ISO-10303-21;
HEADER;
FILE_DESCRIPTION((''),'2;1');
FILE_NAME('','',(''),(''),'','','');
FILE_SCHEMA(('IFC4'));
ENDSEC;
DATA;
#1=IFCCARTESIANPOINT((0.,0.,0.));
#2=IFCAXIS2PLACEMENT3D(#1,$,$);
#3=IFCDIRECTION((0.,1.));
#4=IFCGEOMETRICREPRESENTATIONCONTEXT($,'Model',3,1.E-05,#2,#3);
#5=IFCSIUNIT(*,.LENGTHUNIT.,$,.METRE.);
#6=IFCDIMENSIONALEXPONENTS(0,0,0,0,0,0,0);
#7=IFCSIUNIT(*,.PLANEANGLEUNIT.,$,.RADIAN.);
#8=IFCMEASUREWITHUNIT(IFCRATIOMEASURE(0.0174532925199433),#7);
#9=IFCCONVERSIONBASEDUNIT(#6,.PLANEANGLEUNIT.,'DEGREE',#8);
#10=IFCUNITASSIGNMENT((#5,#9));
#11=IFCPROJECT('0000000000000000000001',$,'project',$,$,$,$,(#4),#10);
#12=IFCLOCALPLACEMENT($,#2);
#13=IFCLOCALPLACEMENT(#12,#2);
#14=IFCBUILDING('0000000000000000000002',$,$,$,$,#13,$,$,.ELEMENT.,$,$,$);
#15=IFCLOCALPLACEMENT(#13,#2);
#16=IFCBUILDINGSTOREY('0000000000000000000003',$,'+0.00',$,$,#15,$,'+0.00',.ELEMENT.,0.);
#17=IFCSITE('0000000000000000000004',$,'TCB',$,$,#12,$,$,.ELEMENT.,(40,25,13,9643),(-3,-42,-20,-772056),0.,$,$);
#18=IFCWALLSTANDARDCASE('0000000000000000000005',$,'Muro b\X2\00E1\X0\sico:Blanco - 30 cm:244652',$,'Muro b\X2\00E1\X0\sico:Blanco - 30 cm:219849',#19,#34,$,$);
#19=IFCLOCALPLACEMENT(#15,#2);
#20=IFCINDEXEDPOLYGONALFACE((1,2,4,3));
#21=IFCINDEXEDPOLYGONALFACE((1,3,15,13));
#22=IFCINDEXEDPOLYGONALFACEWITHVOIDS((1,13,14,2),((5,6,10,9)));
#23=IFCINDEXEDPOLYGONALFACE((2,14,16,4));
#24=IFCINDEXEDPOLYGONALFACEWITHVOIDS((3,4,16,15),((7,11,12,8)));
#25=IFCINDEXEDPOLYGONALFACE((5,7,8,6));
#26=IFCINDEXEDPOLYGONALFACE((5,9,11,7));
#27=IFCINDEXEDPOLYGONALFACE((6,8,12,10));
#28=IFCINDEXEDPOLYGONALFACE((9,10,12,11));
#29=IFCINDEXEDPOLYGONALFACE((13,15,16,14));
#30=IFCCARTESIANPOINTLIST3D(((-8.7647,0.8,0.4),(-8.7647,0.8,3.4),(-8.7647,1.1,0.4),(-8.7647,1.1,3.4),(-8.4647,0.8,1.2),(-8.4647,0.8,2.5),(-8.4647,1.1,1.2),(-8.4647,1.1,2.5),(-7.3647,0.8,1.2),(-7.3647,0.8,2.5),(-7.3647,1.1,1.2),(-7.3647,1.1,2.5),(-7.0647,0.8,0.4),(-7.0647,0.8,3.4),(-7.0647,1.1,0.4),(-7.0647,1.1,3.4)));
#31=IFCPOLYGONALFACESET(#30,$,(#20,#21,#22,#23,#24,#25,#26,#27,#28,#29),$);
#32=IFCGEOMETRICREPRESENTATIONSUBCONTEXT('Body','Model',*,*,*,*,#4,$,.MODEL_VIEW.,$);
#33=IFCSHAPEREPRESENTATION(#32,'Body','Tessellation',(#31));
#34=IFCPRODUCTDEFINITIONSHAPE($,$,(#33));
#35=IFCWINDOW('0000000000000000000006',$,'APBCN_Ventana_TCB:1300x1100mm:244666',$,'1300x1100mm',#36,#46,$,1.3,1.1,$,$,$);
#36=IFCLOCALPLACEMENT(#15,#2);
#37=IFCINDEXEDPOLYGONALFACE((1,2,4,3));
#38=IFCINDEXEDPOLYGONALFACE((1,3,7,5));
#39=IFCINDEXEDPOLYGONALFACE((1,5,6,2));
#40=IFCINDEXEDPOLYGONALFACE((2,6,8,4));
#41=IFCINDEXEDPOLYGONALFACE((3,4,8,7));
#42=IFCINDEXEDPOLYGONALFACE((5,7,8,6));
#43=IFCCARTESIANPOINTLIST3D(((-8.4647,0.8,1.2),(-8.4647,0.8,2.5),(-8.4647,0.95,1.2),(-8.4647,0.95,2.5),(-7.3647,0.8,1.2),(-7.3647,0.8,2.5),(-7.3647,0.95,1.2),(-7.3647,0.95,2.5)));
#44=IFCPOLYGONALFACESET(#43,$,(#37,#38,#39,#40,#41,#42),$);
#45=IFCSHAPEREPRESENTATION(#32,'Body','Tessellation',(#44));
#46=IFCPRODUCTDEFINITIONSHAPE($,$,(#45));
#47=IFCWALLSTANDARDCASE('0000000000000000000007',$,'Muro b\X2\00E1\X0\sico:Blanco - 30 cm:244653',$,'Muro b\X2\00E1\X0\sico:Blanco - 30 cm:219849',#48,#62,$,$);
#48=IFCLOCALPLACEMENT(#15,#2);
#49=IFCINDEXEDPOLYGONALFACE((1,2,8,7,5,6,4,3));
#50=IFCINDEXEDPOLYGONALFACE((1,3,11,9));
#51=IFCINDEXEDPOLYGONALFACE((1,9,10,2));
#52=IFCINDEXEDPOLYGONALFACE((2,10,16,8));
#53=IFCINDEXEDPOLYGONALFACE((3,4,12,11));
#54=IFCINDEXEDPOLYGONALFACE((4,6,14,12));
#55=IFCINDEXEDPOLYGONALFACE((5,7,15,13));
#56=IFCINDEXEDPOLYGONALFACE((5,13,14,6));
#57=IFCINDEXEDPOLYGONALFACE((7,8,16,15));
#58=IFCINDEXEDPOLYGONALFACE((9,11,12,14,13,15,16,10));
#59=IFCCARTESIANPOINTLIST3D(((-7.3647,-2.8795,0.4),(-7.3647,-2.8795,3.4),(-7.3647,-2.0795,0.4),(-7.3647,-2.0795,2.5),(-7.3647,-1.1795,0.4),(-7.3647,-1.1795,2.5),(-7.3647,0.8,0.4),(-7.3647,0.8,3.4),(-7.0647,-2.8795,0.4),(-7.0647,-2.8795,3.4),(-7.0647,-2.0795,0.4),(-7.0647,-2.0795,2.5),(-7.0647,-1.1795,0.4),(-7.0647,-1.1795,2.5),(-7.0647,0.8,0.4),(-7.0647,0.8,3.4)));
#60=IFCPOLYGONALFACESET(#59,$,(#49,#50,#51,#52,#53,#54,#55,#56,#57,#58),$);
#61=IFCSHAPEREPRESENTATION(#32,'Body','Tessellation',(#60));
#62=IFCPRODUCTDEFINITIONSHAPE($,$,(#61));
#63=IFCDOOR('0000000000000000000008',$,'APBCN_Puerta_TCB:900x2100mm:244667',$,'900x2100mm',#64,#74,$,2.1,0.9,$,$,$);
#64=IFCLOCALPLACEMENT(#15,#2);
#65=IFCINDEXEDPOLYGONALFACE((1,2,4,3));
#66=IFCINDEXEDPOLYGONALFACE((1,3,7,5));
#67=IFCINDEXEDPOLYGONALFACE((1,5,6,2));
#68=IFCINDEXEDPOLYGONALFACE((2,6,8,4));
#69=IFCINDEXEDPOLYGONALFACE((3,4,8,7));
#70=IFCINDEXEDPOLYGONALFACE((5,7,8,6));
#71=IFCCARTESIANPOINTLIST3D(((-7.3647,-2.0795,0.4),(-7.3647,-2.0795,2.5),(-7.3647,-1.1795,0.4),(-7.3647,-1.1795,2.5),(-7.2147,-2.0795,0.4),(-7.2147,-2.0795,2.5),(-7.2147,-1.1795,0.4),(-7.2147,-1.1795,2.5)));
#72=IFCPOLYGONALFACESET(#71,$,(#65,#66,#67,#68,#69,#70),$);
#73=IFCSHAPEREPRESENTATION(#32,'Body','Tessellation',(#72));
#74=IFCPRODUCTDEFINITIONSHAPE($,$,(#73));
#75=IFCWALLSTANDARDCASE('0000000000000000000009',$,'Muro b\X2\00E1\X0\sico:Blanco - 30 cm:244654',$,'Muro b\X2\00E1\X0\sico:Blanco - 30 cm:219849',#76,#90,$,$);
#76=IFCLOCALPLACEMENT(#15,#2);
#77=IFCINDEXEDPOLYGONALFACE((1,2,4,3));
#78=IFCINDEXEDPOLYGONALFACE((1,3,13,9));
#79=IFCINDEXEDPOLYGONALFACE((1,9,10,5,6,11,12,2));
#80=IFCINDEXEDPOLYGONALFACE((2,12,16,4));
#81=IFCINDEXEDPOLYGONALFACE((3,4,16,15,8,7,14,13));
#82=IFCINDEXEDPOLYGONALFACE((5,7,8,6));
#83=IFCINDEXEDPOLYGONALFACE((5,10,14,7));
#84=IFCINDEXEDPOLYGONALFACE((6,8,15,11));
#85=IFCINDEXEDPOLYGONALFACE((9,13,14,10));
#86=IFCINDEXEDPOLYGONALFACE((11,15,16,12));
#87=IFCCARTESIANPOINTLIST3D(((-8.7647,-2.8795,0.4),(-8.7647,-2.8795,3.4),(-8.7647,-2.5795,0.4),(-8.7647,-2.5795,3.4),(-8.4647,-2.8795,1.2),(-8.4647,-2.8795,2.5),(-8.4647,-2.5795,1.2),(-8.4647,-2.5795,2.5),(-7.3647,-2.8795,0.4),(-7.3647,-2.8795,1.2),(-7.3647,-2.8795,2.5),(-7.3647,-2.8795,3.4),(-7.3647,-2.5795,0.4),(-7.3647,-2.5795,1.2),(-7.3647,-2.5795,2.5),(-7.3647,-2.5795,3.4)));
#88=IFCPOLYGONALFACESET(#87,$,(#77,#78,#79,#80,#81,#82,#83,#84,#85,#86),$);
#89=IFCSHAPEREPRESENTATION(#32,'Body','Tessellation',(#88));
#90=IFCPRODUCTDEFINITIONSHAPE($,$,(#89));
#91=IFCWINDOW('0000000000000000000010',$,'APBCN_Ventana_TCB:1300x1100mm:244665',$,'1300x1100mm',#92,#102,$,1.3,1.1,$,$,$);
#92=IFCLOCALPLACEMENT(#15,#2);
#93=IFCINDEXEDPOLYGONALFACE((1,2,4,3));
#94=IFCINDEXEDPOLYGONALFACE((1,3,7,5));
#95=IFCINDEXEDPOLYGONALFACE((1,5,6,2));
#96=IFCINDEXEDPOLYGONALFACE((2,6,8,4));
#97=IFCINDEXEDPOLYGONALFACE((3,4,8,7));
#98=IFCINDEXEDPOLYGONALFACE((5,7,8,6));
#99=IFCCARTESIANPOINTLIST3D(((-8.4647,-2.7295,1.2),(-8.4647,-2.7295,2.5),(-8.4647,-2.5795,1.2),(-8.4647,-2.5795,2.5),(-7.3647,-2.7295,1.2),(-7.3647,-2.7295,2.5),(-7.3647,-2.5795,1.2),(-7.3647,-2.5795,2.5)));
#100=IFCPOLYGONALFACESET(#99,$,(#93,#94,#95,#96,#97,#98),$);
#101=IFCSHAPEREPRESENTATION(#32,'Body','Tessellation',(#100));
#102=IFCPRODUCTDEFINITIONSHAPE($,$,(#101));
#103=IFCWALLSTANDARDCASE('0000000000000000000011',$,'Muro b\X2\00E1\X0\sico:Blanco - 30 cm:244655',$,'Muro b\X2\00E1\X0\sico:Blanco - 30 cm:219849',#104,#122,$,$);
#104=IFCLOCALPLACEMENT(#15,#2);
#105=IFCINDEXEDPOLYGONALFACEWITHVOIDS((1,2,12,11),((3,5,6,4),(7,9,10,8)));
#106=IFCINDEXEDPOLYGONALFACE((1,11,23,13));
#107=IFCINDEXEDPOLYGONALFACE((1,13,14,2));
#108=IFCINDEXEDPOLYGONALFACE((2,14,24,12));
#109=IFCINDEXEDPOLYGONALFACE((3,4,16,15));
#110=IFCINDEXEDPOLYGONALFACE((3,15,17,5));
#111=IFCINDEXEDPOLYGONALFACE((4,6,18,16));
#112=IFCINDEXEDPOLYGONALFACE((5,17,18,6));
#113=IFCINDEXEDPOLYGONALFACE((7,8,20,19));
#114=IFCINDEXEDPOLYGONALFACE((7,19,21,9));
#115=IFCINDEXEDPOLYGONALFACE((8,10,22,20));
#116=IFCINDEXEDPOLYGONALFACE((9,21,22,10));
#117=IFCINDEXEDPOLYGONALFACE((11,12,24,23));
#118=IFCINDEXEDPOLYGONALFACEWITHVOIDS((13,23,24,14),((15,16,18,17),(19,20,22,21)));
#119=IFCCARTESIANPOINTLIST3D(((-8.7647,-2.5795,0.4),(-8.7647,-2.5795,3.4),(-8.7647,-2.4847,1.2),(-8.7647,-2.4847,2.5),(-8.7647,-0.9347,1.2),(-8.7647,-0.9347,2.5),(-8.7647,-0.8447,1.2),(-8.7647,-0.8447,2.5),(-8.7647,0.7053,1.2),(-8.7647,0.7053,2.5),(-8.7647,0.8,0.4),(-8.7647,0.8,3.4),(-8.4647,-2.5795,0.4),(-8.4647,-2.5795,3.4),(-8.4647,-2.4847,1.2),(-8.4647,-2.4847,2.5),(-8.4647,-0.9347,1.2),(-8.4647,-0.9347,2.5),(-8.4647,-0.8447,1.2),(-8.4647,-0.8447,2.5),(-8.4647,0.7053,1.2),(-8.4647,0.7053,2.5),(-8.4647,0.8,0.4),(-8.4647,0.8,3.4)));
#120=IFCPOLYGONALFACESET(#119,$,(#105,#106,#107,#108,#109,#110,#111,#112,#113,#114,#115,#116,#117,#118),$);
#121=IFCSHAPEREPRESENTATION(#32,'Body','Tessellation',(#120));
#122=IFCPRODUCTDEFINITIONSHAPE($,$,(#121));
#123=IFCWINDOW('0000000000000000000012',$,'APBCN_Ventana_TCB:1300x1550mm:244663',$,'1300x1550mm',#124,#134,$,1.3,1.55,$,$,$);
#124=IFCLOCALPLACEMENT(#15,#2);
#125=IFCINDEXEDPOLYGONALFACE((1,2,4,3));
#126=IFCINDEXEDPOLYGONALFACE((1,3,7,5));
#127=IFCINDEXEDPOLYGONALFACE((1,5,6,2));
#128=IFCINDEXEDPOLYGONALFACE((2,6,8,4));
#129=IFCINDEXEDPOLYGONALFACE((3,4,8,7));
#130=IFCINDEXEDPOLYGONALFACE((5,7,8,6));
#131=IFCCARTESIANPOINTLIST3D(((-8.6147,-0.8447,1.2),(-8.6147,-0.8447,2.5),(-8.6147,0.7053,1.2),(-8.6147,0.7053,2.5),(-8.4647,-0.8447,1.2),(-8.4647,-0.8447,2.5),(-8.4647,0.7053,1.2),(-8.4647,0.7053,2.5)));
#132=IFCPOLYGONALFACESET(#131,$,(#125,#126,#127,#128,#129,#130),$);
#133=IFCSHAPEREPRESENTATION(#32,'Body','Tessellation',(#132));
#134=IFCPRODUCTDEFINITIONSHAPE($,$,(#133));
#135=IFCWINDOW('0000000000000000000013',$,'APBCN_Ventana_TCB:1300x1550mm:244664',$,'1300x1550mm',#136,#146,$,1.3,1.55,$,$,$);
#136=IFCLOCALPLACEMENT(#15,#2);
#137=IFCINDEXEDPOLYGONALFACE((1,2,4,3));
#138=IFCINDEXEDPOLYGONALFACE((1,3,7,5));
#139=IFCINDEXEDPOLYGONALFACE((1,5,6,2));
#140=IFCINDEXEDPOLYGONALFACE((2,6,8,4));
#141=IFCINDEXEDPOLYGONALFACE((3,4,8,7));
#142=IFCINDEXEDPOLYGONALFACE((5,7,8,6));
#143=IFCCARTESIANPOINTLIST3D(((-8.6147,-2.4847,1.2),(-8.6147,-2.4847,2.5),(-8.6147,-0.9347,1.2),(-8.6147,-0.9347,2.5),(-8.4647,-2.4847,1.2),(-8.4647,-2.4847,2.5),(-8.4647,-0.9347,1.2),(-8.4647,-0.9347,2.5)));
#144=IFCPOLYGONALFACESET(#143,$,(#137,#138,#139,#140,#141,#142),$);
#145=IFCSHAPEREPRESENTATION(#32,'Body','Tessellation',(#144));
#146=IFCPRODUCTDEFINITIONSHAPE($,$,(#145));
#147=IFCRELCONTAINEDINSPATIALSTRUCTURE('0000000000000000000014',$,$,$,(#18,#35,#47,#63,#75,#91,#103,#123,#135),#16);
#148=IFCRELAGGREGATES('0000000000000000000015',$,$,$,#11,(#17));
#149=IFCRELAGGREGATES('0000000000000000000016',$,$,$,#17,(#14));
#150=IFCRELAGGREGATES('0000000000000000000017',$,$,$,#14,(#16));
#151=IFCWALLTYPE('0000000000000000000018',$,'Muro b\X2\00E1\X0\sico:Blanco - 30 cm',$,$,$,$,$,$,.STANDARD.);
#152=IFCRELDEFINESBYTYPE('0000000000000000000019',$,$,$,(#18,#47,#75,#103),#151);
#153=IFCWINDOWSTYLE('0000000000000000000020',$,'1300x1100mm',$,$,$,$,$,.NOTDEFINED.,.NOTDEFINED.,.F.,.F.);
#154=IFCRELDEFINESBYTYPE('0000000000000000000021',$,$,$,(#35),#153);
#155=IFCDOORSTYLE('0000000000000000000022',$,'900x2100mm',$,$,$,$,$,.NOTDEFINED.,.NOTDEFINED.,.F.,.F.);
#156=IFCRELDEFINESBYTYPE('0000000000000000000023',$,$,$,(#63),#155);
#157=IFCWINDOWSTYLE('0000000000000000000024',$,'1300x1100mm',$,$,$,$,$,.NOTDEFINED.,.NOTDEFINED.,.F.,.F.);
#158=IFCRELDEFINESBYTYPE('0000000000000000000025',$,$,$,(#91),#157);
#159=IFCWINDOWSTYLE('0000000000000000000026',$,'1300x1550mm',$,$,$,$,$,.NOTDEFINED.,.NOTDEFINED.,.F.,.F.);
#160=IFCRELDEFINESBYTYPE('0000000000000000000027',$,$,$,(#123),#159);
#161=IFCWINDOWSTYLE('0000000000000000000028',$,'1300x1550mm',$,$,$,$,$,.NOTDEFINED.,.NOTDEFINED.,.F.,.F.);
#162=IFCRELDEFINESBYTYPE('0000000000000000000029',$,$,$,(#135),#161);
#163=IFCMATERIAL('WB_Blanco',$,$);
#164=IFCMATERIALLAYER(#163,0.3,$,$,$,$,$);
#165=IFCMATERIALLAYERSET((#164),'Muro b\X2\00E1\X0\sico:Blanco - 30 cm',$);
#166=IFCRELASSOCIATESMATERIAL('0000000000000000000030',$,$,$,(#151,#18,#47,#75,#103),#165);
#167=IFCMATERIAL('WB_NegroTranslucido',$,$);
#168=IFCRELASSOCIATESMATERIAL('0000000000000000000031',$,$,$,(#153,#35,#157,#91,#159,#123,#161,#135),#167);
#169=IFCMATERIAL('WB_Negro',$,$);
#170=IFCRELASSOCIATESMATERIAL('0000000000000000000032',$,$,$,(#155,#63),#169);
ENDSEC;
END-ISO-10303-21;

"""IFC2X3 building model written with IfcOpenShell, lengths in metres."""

from ifc_helpers import new_model, entity, si_unit, converted_unit, direction, frame, frame_2d, origin, origin_2d_with_axis, place, context, subcontext, project, spatial, rectangle, extrude, source, transform, mapped, material, layer, layer_set, layer_usage, type_object, type_shapes, element, fill, save


model = new_model("IFC2X3")

# Units and contexts
model_context = context("Model", 3, precision=1e-05, world=origin(), true_north=direction((0.0, 1.0)))
body_context = subcontext(model_context, "Body", "Model", "MODEL_VIEW")
ifc_project = project(units=[si_unit("LENGTHUNIT", "METRE"), converted_unit("PLANEANGLEUNIT", "DEGREE", entity("IfcRatioMeasure", 0.0174532925199433), si_unit("PLANEANGLEUNIT", "RADIAN"), dimensions=[0, 0, 0, 0, 0, 0, 0])], contexts=[model_context])

# Site, building, storey
site_placement = place(None, origin())
site = spatial("IfcSite", under=ifc_project, at=site_placement, Name="TCB", CompositionType="ELEMENT", RefLatitude=(40, 25, 13, 9643), RefLongitude=(-3, -42, -20, -772056), RefElevation=0.0)
building_placement = place(site_placement, origin())
building = spatial("IfcBuilding", under=site, at=building_placement, CompositionType="ELEMENT")
storey_placement = place(building_placement, origin())
storey = spatial("IfcBuildingStorey", under=building, at=storey_placement, Name="+0.00", LongName="+0.00", CompositionType="ELEMENT", Elevation=0.0)

# Wall, opening, window
ifc_material_1 = material(Name="WB_Blanco")
ifc_layer_1 = layer(ifc_material_1, 0.3)
ifc_layer_set_1 = layer_set([ifc_layer_1], Name="Muro básico:Blanco - 30 cm")
ifc_layer_usage_1 = layer_usage(ifc_layer_set_1, "AXIS2", "NEGATIVE", 0.15)
wall_type = type_object("IfcWallType", Name="Muro básico:Blanco - 30 cm", PredefinedType="STANDARD", material=ifc_layer_set_1)
wall_1_placement = place(storey_placement, frame((-8.7647, 0.95, 0.4)))
wall_1 = element("IfcWallStandardCase", 1, at=wall_1_placement, inside=storey, type_object=wall_type, material=ifc_layer_usage_1, Name="Muro básico:Blanco - 30 cm:244652", ObjectType="Muro básico:Blanco - 30 cm:219849", context=body_context, shape_type="SweptSolid", body=[
    extrude(rectangle(XDim=1.7, YDim=0.3, at=frame_2d((0.85, 0.0), x_axis=(-1.0, 0.0))), origin(), (0.0, 0.0, 1.0), 3.0),
])
opening_1_placement = place(wall_1_placement, frame((0.3, -0.15, 0.8)))
opening_1 = element("IfcOpeningElement", 2, at=opening_1_placement, cuts=wall_1, ObjectType="Opening", context=body_context, shape_type="SweptSolid", body=[
    extrude(rectangle(XDim=1.3, YDim=1.1, at=frame_2d((0.65, 0.55), x_axis=(1.0, 0.0))), frame((0.0, 0.0, 0.0), z_axis=(0.0, 1.0, 0.0), x_axis=(0.0, 0.0, 1.0)), (0.0, 0.0, 1.0), 0.3),
])
ifc_material_2 = material(Name="WB_NegroTranslucido")
window_style_1 = type_object("IfcWindowStyle", Name="1300x1100mm", ConstructionType="NOTDEFINED", OperationType="NOTDEFINED", ParameterTakesPrecedence=False, Sizeable=False, material=ifc_material_2)
shared_shape_1 = source(origin(), body_context, "Body", "SweptSolid", [
    extrude(rectangle(XDim=0.15, YDim=1.1, at=frame_2d((0.0, 0.0), x_axis=(1.0, 0.0))), frame((0.55, 0.075, 0.0), z_axis=(0.0, 0.0, 1.0), x_axis=(0.0, 1.0, 0.0)), (0.0, 0.0, 1.0), 1.3),
])
type_shapes(window_style_1, [shared_shape_1])
window_1_placement = place(opening_1_placement, origin())
window_1 = element("IfcWindow", 3, at=window_1_placement, inside=storey, type_object=window_style_1, material=ifc_material_2, Name="APBCN_Ventana_TCB:1300x1100mm:244666", ObjectType="1300x1100mm", OverallHeight=1.3, OverallWidth=1.1, context=body_context, shape_type="MappedRepresentation", body=[
    mapped(shared_shape_1, transform((0.0, 0.0, 0.0), scale=1.0)),
])
fill(opening_1, window_1)

# Wall, opening, door
ifc_layer_usage_2 = layer_usage(ifc_layer_set_1, "AXIS2", "NEGATIVE", 0.15)
wall_2_placement = place(storey_placement, frame((-7.2147, 0.8, 0.4), z_axis=(0.0, 0.0, 1.0), x_axis=(0.0, -1.0, 0.0)))
wall_2 = element("IfcWallStandardCase", 4, at=wall_2_placement, inside=storey, type_object=wall_type, material=ifc_layer_usage_2, Name="Muro básico:Blanco - 30 cm:244653", ObjectType="Muro básico:Blanco - 30 cm:219849", context=body_context, shape_type="SweptSolid", body=[
    extrude(rectangle(XDim=3.6795, YDim=0.3, at=frame_2d((1.8397, 0.0), x_axis=(-1.0, 0.0))), origin(), (0.0, 0.0, 1.0), 3.0),
])
opening_2_placement = place(wall_2_placement, frame((1.9795, -0.15, 0.0)))
opening_2 = element("IfcOpeningElement", 5, at=opening_2_placement, cuts=wall_2, ObjectType="Opening", context=body_context, shape_type="SweptSolid", body=[
    extrude(rectangle(XDim=2.1, YDim=0.9, at=frame_2d((1.05, 0.45), x_axis=(1.0, 0.0))), frame((0.0, 0.0, 0.0), z_axis=(0.0, 1.0, 0.0), x_axis=(0.0, 0.0, 1.0)), (0.0, 0.0, 1.0), 0.3),
])
ifc_material_3 = material(Name="WB_Negro")
door_style = type_object("IfcDoorStyle", Name="900x2100mm", ConstructionType="NOTDEFINED", OperationType="NOTDEFINED", ParameterTakesPrecedence=False, Sizeable=False, material=ifc_material_3)
shared_shape_2 = source(origin(), body_context, "Body", "SweptSolid", [
    extrude(rectangle(XDim=0.15, YDim=0.9, at=frame_2d((0.0, 0.0), x_axis=(1.0, 0.0))), frame((0.45, 0.075, 0.0), z_axis=(0.0, 0.0, 1.0), x_axis=(0.0, 1.0, 0.0)), (0.0, 0.0, 1.0), 2.1),
])
type_shapes(door_style, [shared_shape_2])
door_1_placement = place(opening_2_placement, origin())
door_1 = element("IfcDoor", 6, at=door_1_placement, inside=storey, type_object=door_style, material=ifc_material_3, Name="APBCN_Puerta_TCB:900x2100mm:244667", ObjectType="900x2100mm", OverallHeight=2.1, OverallWidth=0.9, context=body_context, shape_type="MappedRepresentation", body=[
    mapped(shared_shape_2, transform((0.0, 0.0, 0.0), scale=1.0)),
])
fill(opening_2, door_1)

# Wall, opening, window
ifc_layer_usage_3 = layer_usage(ifc_layer_set_1, "AXIS2", "NEGATIVE", 0.15)
wall_3_placement = place(storey_placement, frame((-7.3647, -2.7295, 0.4), z_axis=(0.0, 0.0, 1.0), x_axis=(-1.0, 0.0, 0.0)))
wall_3 = element("IfcWallStandardCase", 7, at=wall_3_placement, inside=storey, type_object=wall_type, material=ifc_layer_usage_3, Name="Muro básico:Blanco - 30 cm:244654", ObjectType="Muro básico:Blanco - 30 cm:219849", context=body_context, shape_type="SweptSolid", body=[
    extrude(rectangle(XDim=1.4, YDim=0.3, at=frame_2d((0.7, 0.0), x_axis=(-1.0, 0.0))), origin(), (0.0, 0.0, 1.0), 3.0),
])
opening_3_placement = place(wall_3_placement, frame((0.0, -0.15, 0.8)))
opening_3 = element("IfcOpeningElement", 8, at=opening_3_placement, cuts=wall_3, ObjectType="Opening", context=body_context, shape_type="SweptSolid", body=[
    extrude(rectangle(XDim=1.3, YDim=1.1, at=frame_2d((0.65, 0.55), x_axis=(1.0, 0.0))), frame((0.0, 0.0, 0.0), z_axis=(0.0, 1.0, 0.0), x_axis=(0.0, 0.0, 1.0)), (0.0, 0.0, 1.0), 0.3),
])
window_style_2 = type_object("IfcWindowStyle", Name="1300x1100mm", ConstructionType="NOTDEFINED", OperationType="NOTDEFINED", ParameterTakesPrecedence=False, Sizeable=False, material=ifc_material_2)
shared_shape_3 = source(origin(), body_context, "Body", "SweptSolid", [
    extrude(rectangle(XDim=1.1, YDim=0.15, at=origin_2d_with_axis()), frame((0.55, 0.075, 0.0)), (0.0, 0.0, 1.0), 1.3),
])
type_shapes(window_style_2, [shared_shape_3])
window_2_placement = place(opening_3_placement, origin())
window_2 = element("IfcWindow", 9, at=window_2_placement, inside=storey, type_object=window_style_2, material=ifc_material_2, Name="APBCN_Ventana_TCB:1300x1100mm:244665", ObjectType="1300x1100mm", OverallHeight=1.3, OverallWidth=1.1, context=body_context, shape_type="MappedRepresentation", body=[
    mapped(shared_shape_3, transform((0.0, 0.0, 0.0), scale=1.0)),
])
fill(opening_3, window_2)

# Wall, openings, windows
ifc_layer_usage_4 = layer_usage(ifc_layer_set_1, "AXIS2", "NEGATIVE", 0.15)
wall_4_placement = place(storey_placement, frame((-8.6147, -2.5795, 0.4), z_axis=(0.0, 0.0, 1.0), x_axis=(0.0, 1.0, 0.0)))
wall_4 = element("IfcWallStandardCase", 10, at=wall_4_placement, inside=storey, type_object=wall_type, material=ifc_layer_usage_4, Name="Muro básico:Blanco - 30 cm:244655", ObjectType="Muro básico:Blanco - 30 cm:219849", context=body_context, shape_type="SweptSolid", body=[
    extrude(rectangle(XDim=3.3795, YDim=0.3, at=frame_2d((1.6897, 0.0), x_axis=(-1.0, 0.0))), origin(), (0.0, 0.0, 1.0), 3.0),
])
opening_4_placement = place(wall_4_placement, frame((1.7347, -0.15, 0.8)))
opening_4 = element("IfcOpeningElement", 11, at=opening_4_placement, cuts=wall_4, ObjectType="Opening", context=body_context, shape_type="SweptSolid", body=[
    extrude(rectangle(XDim=1.3, YDim=1.55, at=frame_2d((0.65, 0.775), x_axis=(1.0, 0.0))), frame((0.0, 0.0, 0.0), z_axis=(0.0, 1.0, 0.0), x_axis=(0.0, 0.0, 1.0)), (0.0, 0.0, 1.0), 0.3),
])
opening_5_placement = place(wall_4_placement, frame((0.0947, -0.15, 0.8)))
opening_5 = element("IfcOpeningElement", 12, at=opening_5_placement, cuts=wall_4, ObjectType="Opening", context=body_context, shape_type="SweptSolid", body=[
    extrude(rectangle(XDim=1.3, YDim=1.55, at=frame_2d((0.65, 0.775), x_axis=(1.0, 0.0))), frame((0.0, 0.0, 0.0), z_axis=(0.0, 1.0, 0.0), x_axis=(0.0, 0.0, 1.0)), (0.0, 0.0, 1.0), 0.3),
])
window_style_3 = type_object("IfcWindowStyle", Name="1300x1550mm", ConstructionType="NOTDEFINED", OperationType="NOTDEFINED", ParameterTakesPrecedence=False, Sizeable=False, material=ifc_material_2)
shared_shape_4 = source(origin(), body_context, "Body", "SweptSolid", [
    extrude(rectangle(XDim=1.55, YDim=0.15, at=origin_2d_with_axis()), frame((0.775, 0.075, 0.0)), (0.0, 0.0, 1.0), 1.3),
])
type_shapes(window_style_3, [shared_shape_4])
window_3_placement = place(opening_4_placement, origin())
window_3 = element("IfcWindow", 13, at=window_3_placement, inside=storey, type_object=window_style_3, material=ifc_material_2, Name="APBCN_Ventana_TCB:1300x1550mm:244663", ObjectType="1300x1550mm", OverallHeight=1.3, OverallWidth=1.55, context=body_context, shape_type="MappedRepresentation", body=[
    mapped(shared_shape_4, transform((0.0, 0.0, 0.0), scale=1.0)),
])
fill(opening_4, window_3)
window_style_4 = type_object("IfcWindowStyle", Name="1300x1550mm", ConstructionType="NOTDEFINED", OperationType="NOTDEFINED", ParameterTakesPrecedence=False, Sizeable=False, material=ifc_material_2)
shared_shape_5 = source(origin(), body_context, "Body", "SweptSolid", [
    extrude(rectangle(XDim=0.15, YDim=1.55, at=origin_2d_with_axis()), frame((0.775, 0.075, 0.0), z_axis=(0.0, 0.0, 1.0), x_axis=(0.0, 1.0, 0.0)), (0.0, 0.0, 1.0), 1.3),
])
type_shapes(window_style_4, [shared_shape_5])
window_4_placement = place(opening_5_placement, origin())
window_4 = element("IfcWindow", 14, at=window_4_placement, inside=storey, type_object=window_style_4, material=ifc_material_2, Name="APBCN_Ventana_TCB:1300x1550mm:244664", ObjectType="1300x1550mm", OverallHeight=1.3, OverallWidth=1.55, context=body_context, shape_type="MappedRepresentation", body=[
    mapped(shared_shape_5, transform((0.0, 0.0, 0.0), scale=1.0)),
])
fill(opening_5, window_4)

save(model, "model.ifc")
